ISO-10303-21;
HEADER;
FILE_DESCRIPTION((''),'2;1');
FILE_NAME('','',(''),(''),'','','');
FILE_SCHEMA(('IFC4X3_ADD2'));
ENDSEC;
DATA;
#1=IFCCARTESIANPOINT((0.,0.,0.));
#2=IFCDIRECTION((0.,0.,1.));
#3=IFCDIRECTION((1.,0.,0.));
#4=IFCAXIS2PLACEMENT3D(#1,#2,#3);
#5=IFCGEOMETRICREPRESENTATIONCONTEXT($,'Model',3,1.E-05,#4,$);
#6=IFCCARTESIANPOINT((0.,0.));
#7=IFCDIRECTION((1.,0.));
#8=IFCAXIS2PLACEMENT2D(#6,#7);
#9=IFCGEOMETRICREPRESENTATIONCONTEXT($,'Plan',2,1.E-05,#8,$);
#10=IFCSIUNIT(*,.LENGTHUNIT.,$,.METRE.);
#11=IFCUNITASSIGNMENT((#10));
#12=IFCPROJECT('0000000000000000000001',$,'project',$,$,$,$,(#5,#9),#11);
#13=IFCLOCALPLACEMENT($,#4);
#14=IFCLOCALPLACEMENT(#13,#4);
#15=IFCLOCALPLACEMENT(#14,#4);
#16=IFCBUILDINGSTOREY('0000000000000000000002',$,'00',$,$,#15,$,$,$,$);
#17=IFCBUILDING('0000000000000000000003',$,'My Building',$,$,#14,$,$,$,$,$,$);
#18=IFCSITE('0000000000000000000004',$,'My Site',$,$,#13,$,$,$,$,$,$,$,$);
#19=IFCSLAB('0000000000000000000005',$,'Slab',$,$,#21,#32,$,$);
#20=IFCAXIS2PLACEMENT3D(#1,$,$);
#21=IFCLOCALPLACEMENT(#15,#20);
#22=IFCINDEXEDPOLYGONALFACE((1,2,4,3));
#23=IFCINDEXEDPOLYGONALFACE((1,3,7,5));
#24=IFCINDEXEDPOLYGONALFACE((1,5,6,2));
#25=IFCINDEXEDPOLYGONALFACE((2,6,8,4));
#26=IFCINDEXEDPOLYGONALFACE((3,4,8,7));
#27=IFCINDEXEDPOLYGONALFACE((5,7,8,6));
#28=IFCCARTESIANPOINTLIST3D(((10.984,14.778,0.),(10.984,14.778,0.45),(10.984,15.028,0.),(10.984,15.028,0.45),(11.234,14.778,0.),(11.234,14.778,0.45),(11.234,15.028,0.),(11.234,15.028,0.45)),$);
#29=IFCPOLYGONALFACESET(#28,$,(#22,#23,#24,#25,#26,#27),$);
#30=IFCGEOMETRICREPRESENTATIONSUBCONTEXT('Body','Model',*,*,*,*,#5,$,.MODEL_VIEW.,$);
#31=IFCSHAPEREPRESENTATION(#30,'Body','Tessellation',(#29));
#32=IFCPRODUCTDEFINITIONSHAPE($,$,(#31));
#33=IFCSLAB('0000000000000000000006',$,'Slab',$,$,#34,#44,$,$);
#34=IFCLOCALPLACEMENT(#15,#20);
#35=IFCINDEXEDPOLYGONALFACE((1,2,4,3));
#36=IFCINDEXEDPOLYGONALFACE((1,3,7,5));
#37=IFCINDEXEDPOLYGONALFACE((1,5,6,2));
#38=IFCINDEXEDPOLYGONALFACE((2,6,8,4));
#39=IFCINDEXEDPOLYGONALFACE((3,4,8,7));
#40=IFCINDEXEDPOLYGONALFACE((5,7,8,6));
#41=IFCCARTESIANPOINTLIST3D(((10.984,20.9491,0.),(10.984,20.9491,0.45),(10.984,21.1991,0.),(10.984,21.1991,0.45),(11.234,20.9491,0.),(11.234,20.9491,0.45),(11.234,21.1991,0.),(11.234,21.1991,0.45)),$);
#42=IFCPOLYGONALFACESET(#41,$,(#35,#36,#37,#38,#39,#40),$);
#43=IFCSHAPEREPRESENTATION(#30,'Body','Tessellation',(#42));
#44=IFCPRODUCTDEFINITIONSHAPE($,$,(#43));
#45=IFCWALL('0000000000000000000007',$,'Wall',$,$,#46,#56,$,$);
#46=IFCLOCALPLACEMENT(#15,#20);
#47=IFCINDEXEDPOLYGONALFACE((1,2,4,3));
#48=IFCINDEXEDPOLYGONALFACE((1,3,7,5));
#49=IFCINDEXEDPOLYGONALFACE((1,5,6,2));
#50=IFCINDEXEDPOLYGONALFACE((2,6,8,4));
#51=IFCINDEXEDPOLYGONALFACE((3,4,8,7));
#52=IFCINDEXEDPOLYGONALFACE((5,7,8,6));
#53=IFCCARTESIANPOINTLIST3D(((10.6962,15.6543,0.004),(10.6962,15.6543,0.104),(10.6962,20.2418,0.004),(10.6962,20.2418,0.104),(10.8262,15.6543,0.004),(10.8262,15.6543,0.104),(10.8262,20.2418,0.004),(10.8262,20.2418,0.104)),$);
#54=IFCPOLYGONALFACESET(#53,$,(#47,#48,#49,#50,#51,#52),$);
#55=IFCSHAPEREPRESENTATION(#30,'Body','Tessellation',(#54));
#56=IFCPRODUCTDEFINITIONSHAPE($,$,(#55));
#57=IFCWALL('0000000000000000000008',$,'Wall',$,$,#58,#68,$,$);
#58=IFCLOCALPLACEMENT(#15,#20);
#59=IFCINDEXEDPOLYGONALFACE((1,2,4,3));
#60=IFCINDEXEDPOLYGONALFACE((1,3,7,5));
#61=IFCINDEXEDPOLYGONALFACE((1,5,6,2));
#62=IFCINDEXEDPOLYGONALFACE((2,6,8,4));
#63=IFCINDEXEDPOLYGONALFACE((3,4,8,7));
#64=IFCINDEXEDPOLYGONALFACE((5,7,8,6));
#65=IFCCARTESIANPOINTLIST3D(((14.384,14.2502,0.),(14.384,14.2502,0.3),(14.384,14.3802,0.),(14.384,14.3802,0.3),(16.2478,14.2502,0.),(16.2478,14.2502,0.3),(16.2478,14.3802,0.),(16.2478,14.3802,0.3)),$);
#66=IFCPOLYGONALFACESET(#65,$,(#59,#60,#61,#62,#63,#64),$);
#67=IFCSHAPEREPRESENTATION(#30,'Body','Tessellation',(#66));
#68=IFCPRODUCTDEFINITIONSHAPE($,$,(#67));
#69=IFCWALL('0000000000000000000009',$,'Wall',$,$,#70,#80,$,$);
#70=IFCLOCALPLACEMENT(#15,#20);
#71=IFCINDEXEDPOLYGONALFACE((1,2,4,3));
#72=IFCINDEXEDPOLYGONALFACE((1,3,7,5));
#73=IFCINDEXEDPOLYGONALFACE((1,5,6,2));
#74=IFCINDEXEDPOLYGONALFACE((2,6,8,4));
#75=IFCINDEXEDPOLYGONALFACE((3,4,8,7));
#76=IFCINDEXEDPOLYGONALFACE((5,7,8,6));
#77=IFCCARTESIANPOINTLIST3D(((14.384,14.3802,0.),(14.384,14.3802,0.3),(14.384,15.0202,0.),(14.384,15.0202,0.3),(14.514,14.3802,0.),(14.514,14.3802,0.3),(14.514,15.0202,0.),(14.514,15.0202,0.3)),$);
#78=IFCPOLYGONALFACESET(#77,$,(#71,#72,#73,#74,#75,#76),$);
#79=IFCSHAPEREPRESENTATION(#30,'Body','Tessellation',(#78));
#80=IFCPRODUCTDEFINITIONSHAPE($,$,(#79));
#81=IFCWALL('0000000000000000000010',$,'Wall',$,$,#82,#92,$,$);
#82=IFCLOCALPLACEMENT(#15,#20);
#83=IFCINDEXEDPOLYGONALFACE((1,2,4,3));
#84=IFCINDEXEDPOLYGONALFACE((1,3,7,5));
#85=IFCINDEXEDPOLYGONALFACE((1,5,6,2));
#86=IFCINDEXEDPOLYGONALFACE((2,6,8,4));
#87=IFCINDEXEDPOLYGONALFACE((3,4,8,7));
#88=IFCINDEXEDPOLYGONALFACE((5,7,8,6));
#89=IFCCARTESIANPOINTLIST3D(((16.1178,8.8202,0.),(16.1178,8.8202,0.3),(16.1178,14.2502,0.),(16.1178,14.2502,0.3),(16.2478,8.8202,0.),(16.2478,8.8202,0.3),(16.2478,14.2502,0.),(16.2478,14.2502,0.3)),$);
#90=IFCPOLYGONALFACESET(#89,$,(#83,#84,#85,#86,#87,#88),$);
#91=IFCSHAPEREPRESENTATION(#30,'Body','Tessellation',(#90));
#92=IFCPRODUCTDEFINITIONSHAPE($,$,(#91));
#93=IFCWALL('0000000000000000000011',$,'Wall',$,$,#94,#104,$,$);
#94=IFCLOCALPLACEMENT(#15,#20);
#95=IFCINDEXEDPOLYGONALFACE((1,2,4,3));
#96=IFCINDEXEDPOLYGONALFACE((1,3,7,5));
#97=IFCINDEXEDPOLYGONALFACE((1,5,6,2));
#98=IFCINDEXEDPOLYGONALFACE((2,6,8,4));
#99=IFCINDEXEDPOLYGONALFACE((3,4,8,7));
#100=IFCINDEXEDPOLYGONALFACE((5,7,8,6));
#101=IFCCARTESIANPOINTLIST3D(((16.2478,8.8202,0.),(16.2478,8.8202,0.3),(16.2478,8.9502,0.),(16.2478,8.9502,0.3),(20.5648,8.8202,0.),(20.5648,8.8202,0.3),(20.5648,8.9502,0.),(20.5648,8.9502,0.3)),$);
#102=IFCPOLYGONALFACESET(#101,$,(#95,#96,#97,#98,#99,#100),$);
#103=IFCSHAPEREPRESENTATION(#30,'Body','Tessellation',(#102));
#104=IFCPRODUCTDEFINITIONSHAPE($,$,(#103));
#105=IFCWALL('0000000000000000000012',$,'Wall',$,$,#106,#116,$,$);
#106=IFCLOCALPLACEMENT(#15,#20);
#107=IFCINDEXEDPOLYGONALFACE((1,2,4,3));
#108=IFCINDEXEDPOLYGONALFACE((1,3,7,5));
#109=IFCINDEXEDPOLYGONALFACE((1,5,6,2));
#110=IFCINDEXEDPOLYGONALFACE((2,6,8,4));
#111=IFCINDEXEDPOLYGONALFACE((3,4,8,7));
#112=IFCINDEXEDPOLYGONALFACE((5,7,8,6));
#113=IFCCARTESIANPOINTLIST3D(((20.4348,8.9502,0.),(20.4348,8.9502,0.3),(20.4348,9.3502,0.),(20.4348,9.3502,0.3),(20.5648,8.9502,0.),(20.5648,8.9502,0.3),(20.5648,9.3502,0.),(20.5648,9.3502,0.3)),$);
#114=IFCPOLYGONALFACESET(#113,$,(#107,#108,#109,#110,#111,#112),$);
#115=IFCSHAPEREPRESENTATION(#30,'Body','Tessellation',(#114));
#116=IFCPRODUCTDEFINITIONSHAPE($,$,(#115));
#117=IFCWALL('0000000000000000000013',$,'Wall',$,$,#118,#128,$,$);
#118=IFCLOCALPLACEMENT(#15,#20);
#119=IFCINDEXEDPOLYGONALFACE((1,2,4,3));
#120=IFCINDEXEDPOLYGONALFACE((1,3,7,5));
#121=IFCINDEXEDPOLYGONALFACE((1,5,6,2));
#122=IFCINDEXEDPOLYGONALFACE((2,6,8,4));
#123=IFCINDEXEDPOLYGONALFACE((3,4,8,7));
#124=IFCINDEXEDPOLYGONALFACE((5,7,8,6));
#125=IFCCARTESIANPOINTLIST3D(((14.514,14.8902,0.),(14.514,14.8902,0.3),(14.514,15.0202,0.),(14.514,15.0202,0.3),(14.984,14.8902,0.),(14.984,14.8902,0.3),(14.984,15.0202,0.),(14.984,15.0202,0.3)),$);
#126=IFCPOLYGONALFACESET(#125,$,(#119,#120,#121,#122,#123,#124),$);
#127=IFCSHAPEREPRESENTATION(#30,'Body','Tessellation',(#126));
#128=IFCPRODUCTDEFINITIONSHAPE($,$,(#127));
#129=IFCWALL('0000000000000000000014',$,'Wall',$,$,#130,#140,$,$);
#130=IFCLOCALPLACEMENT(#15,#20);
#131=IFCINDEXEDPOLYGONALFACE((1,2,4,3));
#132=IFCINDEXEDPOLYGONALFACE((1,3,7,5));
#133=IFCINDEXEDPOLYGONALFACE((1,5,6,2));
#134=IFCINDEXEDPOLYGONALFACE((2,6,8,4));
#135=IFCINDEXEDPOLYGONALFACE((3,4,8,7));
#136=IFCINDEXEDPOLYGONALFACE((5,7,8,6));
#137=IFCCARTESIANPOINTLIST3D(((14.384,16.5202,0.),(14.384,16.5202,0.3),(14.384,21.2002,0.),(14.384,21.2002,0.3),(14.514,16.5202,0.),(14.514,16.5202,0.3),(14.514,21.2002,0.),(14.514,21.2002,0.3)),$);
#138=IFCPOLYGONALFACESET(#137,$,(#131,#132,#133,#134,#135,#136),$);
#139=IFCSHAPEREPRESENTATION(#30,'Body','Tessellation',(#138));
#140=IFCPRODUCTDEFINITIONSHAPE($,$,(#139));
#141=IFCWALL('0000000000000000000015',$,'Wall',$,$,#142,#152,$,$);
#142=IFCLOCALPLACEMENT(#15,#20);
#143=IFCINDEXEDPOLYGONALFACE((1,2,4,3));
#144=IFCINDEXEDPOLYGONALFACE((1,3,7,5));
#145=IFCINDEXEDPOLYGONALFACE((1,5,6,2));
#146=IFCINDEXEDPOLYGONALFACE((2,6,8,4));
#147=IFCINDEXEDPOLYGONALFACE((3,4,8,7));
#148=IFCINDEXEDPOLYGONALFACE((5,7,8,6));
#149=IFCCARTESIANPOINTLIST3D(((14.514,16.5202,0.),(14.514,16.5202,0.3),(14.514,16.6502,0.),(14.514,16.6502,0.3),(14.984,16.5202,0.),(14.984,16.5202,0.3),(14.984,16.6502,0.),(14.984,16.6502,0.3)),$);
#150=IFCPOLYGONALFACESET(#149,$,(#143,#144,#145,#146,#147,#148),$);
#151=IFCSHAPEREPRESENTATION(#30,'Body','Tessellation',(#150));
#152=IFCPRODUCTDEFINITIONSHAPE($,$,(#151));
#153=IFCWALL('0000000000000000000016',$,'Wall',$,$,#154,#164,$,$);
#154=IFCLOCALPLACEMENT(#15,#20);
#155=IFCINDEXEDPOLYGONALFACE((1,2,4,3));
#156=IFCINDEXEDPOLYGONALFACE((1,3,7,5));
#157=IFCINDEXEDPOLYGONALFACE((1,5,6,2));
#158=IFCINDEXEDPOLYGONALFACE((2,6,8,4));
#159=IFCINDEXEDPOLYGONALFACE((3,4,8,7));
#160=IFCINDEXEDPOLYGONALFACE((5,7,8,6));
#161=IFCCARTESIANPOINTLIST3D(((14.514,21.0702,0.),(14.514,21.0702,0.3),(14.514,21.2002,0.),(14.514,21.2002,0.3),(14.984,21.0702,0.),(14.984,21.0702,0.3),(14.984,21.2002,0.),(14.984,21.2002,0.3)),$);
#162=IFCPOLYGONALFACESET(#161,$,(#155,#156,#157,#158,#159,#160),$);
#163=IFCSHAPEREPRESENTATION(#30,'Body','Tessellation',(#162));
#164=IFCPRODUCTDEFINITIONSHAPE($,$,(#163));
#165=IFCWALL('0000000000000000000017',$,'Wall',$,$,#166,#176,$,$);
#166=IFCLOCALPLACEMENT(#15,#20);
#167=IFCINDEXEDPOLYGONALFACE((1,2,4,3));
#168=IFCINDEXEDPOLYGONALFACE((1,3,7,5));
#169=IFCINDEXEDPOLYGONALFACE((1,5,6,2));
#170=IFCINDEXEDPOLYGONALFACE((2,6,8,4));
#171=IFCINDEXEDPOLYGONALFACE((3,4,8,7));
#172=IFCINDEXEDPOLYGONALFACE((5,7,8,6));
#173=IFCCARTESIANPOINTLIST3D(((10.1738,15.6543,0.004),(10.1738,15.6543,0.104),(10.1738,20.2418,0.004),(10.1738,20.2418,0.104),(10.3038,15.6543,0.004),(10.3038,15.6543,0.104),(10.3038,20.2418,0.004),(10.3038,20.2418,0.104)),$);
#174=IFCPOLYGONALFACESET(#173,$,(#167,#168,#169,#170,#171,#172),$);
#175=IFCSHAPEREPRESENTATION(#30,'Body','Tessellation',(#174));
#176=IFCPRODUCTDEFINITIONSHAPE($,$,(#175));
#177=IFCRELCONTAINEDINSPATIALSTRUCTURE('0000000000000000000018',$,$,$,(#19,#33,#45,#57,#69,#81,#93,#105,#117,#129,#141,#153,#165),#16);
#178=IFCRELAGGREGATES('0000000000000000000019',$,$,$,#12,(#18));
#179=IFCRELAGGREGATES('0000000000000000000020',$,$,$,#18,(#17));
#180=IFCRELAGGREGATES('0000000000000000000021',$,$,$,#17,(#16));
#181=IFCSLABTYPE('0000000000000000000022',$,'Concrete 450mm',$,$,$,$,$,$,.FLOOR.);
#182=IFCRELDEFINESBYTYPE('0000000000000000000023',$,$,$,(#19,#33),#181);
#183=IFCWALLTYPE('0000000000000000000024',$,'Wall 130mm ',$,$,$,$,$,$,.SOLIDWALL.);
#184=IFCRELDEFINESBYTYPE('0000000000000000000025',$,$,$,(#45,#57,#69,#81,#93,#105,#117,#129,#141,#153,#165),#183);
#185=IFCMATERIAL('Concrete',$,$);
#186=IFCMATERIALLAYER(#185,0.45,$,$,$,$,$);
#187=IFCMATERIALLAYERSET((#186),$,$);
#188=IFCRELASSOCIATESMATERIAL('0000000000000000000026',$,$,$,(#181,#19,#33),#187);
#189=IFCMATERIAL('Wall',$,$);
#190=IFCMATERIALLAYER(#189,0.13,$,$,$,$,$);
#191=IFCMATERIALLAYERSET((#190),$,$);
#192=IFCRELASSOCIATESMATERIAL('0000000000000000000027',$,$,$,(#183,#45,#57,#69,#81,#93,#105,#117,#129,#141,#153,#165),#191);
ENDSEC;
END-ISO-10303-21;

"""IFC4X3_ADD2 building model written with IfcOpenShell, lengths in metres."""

from ifc_helpers import new_model, si_unit, frame, origin_with_axes, origin_2d_with_axis, place, context, subcontext, project, spatial, line, indexed_curve, outline, extrude, material, layer, layer_set, layer_usage, type_object, element, save


model = new_model("IFC4X3_ADD2")

# Units and contexts
model_context = context("Model", 3, precision=1e-05, world=origin_with_axes())
plan_context = context("Plan", 2, precision=1e-05, world=origin_2d_with_axis())
body_context = subcontext(model_context, "Body", "Model", "MODEL_VIEW")
ifc_project = project(units=[si_unit("LENGTHUNIT", "METRE")], contexts=[model_context, plan_context])

# Site, building, storey
site_placement = place(None, origin_with_axes())
site = spatial("IfcSite", under=ifc_project, at=site_placement, Name="My Site")
building_placement = place(site_placement, origin_with_axes())
building = spatial("IfcBuilding", under=site, at=building_placement, Name="My Building")
storey_placement = place(building_placement, origin_with_axes())
storey = spatial("IfcBuildingStorey", under=building, at=storey_placement, Name="00")

# Slabs
ifc_material_1 = material(Name="Concrete")
ifc_layer_1 = layer(ifc_material_1, 0.45)
ifc_layer_set_1 = layer_set([ifc_layer_1])
ifc_layer_usage_1 = layer_usage(ifc_layer_set_1, "AXIS3", "POSITIVE", 0.0)
slab_type = type_object("IfcSlabType", Name="Concrete 450mm", PredefinedType="FLOOR", material=ifc_layer_set_1)
slab_1_placement = place(storey_placement, frame((11.234, 15.028, 0.0), z_axis=(0.0, 0.0, 1.0), x_axis=(1.0, 0.0, 0.0)))
element("IfcSlab", 1, at=slab_1_placement, inside=storey, type_object=slab_type, material=ifc_layer_usage_1, Name="Slab", context=body_context, shape_type="SweptSolid", body=[
    extrude(outline(indexed_curve([(-0.25, 0.0), (-0.25, -0.25), (0.0, -0.25), (0.0, 0.0)], segments=[line(3, 2), line(2, 1), line(1, 4), line(4, 3)], self_intersect=False)), None, (0.0, 0.0, 1.0), 0.45),
])
ifc_layer_usage_2 = layer_usage(ifc_layer_set_1, "AXIS3", "POSITIVE", 0.0)
slab_2_placement = place(storey_placement, frame((11.234, 21.1991, 0.0), z_axis=(0.0, 0.0, 1.0), x_axis=(1.0, 0.0, 0.0)))
element("IfcSlab", 2, at=slab_2_placement, inside=storey, type_object=slab_type, material=ifc_layer_usage_2, Name="Slab", context=body_context, shape_type="SweptSolid", body=[
    extrude(outline(indexed_curve([(-0.25, 0.0), (-0.25, -0.25), (0.0, -0.25), (0.0, 0.0)], segments=[line(3, 2), line(2, 1), line(1, 4), line(4, 3)], self_intersect=False)), None, (0.0, 0.0, 1.0), 0.45),
])

# Walls
ifc_material_2 = material(Name="Wall")
ifc_layer_2 = layer(ifc_material_2, 0.13)
ifc_layer_set_2 = layer_set([ifc_layer_2])
ifc_layer_usage_3 = layer_usage(ifc_layer_set_2, "AXIS2", "POSITIVE", 0.0)
wall_type_1 = type_object("IfcWallType", Name="Wall 130mm ", PredefinedType="SOLIDWALL", material=ifc_layer_set_2)
wall_1_placement = place(storey_placement, frame((10.8262, 15.6543, 0.004), z_axis=(0.0, 0.0, 1.0), x_axis=(0.000001, 1.0, 0.0)))
element("IfcWall", 3, at=wall_1_placement, inside=storey, type_object=wall_type_1, material=ifc_layer_usage_3, Name="Wall", context=body_context, shape_type="SweptSolid", body=[
    extrude(outline(indexed_curve([(0.0, 0.0), (0.0, 0.13), (4.5875, 0.13), (4.5875, 0.0), (0.0, 0.0)], self_intersect=False)), origin_with_axes(), (0.0, 0.0, 1.0), 0.1),
])
ifc_layer_usage_4 = layer_usage(ifc_layer_set_2, "AXIS2", "POSITIVE", 0.0)
wall_2_placement = place(storey_placement, frame((14.384, 14.2502, 0.0), z_axis=(0.0, 0.0, 1.0), x_axis=(1.0, 0.0, 0.0)))
element("IfcWall", 4, at=wall_2_placement, inside=storey, type_object=wall_type_1, material=ifc_layer_usage_4, Name="Wall", context=body_context, shape_type="SweptSolid", body=[
    extrude(outline(indexed_curve([(0.0, 0.0), (0.0, 0.13), (1.8638, 0.13), (1.8638, 0.0), (0.0, 0.0)], self_intersect=False)), origin_with_axes(), (0.0, 0.0, 1.0), 0.3),
])
ifc_layer_usage_5 = layer_usage(ifc_layer_set_2, "AXIS2", "POSITIVE", 0.0)
wall_3_placement = place(storey_placement, frame((14.514, 14.3802, 0.0), z_axis=(0.0, 0.0, 1.0), x_axis=(0.0, 1.0, 0.0)))
element("IfcWall", 5, at=wall_3_placement, inside=storey, type_object=wall_type_1, material=ifc_layer_usage_5, Name="Wall", context=body_context, shape_type="SweptSolid", body=[
    extrude(outline(indexed_curve([(0.0, 0.0), (0.0, 0.13), (0.64, 0.13), (0.64, 0.0), (0.0, 0.0)], self_intersect=False)), origin_with_axes(), (0.0, 0.0, 1.0), 0.3),
])
ifc_layer_usage_6 = layer_usage(ifc_layer_set_2, "AXIS2", "POSITIVE", 0.0)
wall_4_placement = place(storey_placement, frame((16.2478, 8.8202, 0.0), z_axis=(0.0, 0.0, 1.0), x_axis=(0.0, 1.0, 0.0)))
element("IfcWall", 6, at=wall_4_placement, inside=storey, type_object=wall_type_1, material=ifc_layer_usage_6, Name="Wall", context=body_context, shape_type="SweptSolid", body=[
    extrude(outline(indexed_curve([(0.0, 0.0), (0.0, 0.13), (5.43, 0.13), (5.43, 0.0), (0.0, 0.0)], self_intersect=False)), origin_with_axes(), (0.0, 0.0, 1.0), 0.3),
])
ifc_layer_usage_7 = layer_usage(ifc_layer_set_2, "AXIS2", "POSITIVE", 0.0)
wall_5_placement = place(storey_placement, frame((16.2478, 8.8202, 0.0), z_axis=(0.0, 0.0, 1.0), x_axis=(1.0, 0.0, 0.0)))
element("IfcWall", 7, at=wall_5_placement, inside=storey, type_object=wall_type_1, material=ifc_layer_usage_7, Name="Wall", context=body_context, shape_type="SweptSolid", body=[
    extrude(outline(indexed_curve([(0.0, 0.0), (0.0, 0.13), (4.317, 0.13), (4.317, 0.0), (0.0, 0.0)], self_intersect=False)), origin_with_axes(), (0.0, 0.0, 1.0), 0.3),
])
ifc_layer_usage_8 = layer_usage(ifc_layer_set_2, "AXIS2", "POSITIVE", 0.0)
wall_6_placement = place(storey_placement, frame((20.5648, 8.9502, 0.0), z_axis=(0.0, 0.0, 1.0), x_axis=(0.0, 1.0, 0.0)))
element("IfcWall", 8, at=wall_6_placement, inside=storey, type_object=wall_type_1, material=ifc_layer_usage_8, Name="Wall", context=body_context, shape_type="SweptSolid", body=[
    extrude(outline(indexed_curve([(0.0, 0.0), (0.0, 0.13), (0.4, 0.13), (0.4, 0.0), (0.0, 0.0)], self_intersect=False)), origin_with_axes(), (0.0, 0.0, 1.0), 0.3),
])
ifc_layer_usage_9 = layer_usage(ifc_layer_set_2, "AXIS2", "POSITIVE", 0.0)
wall_7_placement = place(storey_placement, frame((14.514, 14.8902, 0.0), z_axis=(0.0, 0.0, 1.0), x_axis=(1.0, 0.0, 0.0)))
element("IfcWall", 9, at=wall_7_placement, inside=storey, type_object=wall_type_1, material=ifc_layer_usage_9, Name="Wall", context=body_context, shape_type="SweptSolid", body=[
    extrude(outline(indexed_curve([(0.0, 0.0), (0.0, 0.13), (0.47, 0.13), (0.47, 0.0), (0.0, 0.0)], self_intersect=False)), origin_with_axes(), (0.0, 0.0, 1.0), 0.3),
])
ifc_layer_usage_10 = layer_usage(ifc_layer_set_2, "AXIS2", "POSITIVE", 0.0)
wall_8_placement = place(storey_placement, frame((14.514, 16.5202, 0.0), z_axis=(0.0, 0.0, 1.0), x_axis=(0.0, 1.0, 0.0)))
element("IfcWall", 10, at=wall_8_placement, inside=storey, type_object=wall_type_1, material=ifc_layer_usage_10, Name="Wall", context=body_context, shape_type="SweptSolid", body=[
    extrude(outline(indexed_curve([(0.0, 0.0), (0.0, 0.13), (4.68, 0.13), (4.68, 0.0), (0.0, 0.0)], self_intersect=False)), origin_with_axes(), (0.0, 0.0, 1.0), 0.3),
])
ifc_layer_usage_11 = layer_usage(ifc_layer_set_2, "AXIS2", "POSITIVE", 0.0)
wall_9_placement = place(storey_placement, frame((14.514, 16.5202, 0.0), z_axis=(0.0, 0.0, 1.0), x_axis=(1.0, 0.0, 0.0)))
element("IfcWall", 11, at=wall_9_placement, inside=storey, type_object=wall_type_1, material=ifc_layer_usage_11, Name="Wall", context=body_context, shape_type="SweptSolid", body=[
    extrude(outline(indexed_curve([(0.0, 0.0), (0.0, 0.13), (0.47, 0.13), (0.47, 0.0), (0.0, 0.0)], self_intersect=False)), origin_with_axes(), (0.0, 0.0, 1.0), 0.3),
])
ifc_layer_usage_12 = layer_usage(ifc_layer_set_2, "AXIS2", "POSITIVE", 0.0)
wall_10_placement = place(storey_placement, frame((14.514, 21.0702, 0.0), z_axis=(0.0, 0.0, 1.0), x_axis=(1.0, 0.0, 0.0)))
element("IfcWall", 12, at=wall_10_placement, inside=storey, type_object=wall_type_1, material=ifc_layer_usage_12, Name="Wall", context=body_context, shape_type="SweptSolid", body=[
    extrude(outline(indexed_curve([(0.0, 0.0), (0.0, 0.13), (0.47, 0.13), (0.47, 0.0), (0.0, 0.0)], self_intersect=False)), origin_with_axes(), (0.0, 0.0, 1.0), 0.3),
])
ifc_layer_usage_13 = layer_usage(ifc_layer_set_2, "AXIS2", "POSITIVE", 0.0)
wall_11_placement = place(storey_placement, frame((10.3038, 15.6543, 0.004), z_axis=(0.0, 0.0, 1.0), x_axis=(0.000001, 1.0, 0.0)))
element("IfcWall", 13, at=wall_11_placement, inside=storey, type_object=wall_type_1, material=ifc_layer_usage_13, Name="Wall", context=body_context, shape_type="SweptSolid", body=[
    extrude(outline(indexed_curve([(0.0, 0.0), (0.0, 0.13), (4.5875, 0.13), (4.5875, 0.0), (0.0, 0.0)], self_intersect=False)), origin_with_axes(), (0.0, 0.0, 1.0), 0.1),
])

save(model, "model.ifc")
